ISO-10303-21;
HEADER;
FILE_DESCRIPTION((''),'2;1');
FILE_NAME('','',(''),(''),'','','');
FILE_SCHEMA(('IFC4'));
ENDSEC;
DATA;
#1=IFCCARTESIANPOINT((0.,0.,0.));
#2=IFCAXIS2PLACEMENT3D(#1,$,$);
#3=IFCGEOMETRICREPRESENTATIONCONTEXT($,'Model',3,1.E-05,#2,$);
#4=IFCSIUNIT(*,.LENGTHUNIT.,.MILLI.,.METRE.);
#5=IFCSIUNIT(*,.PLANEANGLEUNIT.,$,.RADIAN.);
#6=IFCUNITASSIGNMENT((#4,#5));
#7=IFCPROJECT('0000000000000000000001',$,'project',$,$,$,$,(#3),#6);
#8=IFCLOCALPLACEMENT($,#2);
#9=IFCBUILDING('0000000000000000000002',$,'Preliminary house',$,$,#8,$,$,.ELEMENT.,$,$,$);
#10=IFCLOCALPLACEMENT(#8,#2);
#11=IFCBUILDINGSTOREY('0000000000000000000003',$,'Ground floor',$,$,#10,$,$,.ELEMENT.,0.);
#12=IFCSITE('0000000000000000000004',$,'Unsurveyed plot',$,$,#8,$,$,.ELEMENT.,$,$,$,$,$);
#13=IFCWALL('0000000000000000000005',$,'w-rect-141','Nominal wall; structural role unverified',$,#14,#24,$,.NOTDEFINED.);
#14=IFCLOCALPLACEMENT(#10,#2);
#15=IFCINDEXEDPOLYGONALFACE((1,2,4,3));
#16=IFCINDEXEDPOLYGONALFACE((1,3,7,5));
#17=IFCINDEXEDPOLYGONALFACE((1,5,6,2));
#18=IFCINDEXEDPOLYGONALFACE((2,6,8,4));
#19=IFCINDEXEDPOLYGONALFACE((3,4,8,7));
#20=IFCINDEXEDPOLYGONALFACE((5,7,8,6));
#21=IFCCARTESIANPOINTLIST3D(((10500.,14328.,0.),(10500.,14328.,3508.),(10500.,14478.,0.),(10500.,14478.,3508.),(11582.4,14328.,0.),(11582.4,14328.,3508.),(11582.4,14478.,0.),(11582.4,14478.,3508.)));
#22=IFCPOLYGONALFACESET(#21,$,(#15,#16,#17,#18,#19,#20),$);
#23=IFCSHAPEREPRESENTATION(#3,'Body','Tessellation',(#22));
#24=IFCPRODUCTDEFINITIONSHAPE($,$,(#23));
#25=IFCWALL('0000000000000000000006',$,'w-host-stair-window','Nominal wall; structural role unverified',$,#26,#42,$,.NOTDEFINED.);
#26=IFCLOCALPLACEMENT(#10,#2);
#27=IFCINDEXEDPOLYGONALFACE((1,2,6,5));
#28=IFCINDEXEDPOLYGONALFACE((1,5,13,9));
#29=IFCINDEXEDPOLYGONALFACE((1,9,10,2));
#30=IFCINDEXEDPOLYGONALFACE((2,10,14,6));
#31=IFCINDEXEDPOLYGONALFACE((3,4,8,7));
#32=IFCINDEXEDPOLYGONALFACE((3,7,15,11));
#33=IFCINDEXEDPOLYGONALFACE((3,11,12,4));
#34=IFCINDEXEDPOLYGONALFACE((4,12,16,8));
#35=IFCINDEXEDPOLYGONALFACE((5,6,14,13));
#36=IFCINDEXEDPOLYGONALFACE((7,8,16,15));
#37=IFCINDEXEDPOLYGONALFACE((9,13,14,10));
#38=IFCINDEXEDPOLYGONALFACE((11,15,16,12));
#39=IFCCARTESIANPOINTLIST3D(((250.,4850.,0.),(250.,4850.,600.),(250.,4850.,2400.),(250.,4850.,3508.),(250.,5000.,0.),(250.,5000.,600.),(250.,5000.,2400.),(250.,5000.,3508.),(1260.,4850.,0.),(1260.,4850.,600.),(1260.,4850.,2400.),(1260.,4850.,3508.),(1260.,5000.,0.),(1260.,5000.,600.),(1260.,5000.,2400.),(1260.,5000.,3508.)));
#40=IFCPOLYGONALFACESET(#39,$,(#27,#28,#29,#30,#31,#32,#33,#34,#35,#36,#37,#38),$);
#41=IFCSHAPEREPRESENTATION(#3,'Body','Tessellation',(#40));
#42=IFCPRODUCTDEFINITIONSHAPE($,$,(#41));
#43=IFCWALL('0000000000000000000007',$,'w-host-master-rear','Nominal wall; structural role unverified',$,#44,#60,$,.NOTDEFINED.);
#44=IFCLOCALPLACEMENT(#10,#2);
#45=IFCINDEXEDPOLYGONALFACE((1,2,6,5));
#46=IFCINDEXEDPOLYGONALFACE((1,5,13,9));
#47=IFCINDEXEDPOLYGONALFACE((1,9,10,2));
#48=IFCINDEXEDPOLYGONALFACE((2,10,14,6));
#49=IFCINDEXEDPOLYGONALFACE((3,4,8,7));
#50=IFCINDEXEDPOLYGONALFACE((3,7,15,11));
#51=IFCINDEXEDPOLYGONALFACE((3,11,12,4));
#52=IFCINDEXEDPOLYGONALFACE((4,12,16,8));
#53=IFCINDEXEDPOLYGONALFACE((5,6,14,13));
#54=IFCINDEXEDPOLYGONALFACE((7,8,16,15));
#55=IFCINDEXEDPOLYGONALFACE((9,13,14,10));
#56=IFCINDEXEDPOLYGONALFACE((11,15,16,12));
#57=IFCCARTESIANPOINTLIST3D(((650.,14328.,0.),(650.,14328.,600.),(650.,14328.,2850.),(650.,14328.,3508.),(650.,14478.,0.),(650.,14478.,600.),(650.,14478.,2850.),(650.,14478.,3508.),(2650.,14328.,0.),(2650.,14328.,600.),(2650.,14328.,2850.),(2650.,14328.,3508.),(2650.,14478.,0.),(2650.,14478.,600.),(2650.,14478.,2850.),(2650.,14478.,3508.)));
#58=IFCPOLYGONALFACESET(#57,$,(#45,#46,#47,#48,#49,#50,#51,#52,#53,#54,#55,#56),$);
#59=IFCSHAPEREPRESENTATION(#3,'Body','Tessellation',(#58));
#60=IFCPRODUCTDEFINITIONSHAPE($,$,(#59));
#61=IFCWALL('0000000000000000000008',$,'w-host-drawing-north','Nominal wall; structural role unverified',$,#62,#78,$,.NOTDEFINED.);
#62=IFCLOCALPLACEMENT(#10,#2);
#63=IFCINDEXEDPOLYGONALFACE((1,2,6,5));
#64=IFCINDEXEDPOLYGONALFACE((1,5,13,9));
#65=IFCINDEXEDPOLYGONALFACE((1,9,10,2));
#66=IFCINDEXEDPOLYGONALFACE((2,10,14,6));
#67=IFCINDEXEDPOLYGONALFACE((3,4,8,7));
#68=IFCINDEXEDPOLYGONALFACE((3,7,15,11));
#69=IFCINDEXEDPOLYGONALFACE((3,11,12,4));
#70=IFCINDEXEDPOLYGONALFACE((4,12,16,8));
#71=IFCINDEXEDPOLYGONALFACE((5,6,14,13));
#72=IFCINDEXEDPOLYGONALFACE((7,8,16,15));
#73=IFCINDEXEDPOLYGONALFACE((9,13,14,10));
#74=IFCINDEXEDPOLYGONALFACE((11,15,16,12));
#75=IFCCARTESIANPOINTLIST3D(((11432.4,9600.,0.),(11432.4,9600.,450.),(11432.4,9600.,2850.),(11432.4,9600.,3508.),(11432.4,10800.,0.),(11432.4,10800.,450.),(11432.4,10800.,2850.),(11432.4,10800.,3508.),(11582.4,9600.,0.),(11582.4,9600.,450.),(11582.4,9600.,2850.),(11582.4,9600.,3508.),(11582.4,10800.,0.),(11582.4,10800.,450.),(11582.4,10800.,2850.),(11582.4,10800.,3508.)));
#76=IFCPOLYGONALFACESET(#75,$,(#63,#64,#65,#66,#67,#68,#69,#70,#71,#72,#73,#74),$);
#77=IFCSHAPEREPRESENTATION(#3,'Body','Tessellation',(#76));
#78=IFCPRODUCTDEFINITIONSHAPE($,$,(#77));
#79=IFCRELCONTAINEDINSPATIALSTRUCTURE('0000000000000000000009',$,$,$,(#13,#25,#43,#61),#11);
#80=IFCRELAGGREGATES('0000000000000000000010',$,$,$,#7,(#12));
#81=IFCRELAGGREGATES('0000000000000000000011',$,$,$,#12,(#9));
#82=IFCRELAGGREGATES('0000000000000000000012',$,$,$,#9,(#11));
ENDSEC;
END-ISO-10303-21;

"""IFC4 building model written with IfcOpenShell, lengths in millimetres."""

from ifc_helpers import new_model, si_unit, frame, origin, place, context, project, spatial, polyline, outline, extrude, element, save


model = new_model("IFC4")

# Units and contexts
model_context = context("Model", 3, precision=1e-05, world=origin())
ifc_project = project(units=[si_unit("LENGTHUNIT", "METRE", prefix="MILLI"), si_unit("PLANEANGLEUNIT", "RADIAN")], contexts=[model_context])

# Site, building, storey
placement_1 = place(None, origin())
site = spatial("IfcSite", under=ifc_project, at=placement_1, Name="Unsurveyed plot", CompositionType="ELEMENT")
building = spatial("IfcBuilding", under=site, at=placement_1, Name="Preliminary house", CompositionType="ELEMENT")
placement_2 = place(placement_1, origin())
storey = spatial("IfcBuildingStorey", under=building, at=placement_2, Name="Ground floor", CompositionType="ELEMENT", Elevation=0.0)

# Wall
element("IfcWall", 1, at=placement_2, inside=storey, Name="w-rect-141", Description="Nominal wall; structural role unverified", PredefinedType="NOTDEFINED", context=model_context, shape_type="SweptSolid", body=[
    extrude(outline(polyline([(10500.0, 14328.0), (11582.4, 14328.0), (11582.4, 14478.0), (10500.0, 14478.0), (10500.0, 14328.0)])), origin(), (0.0, 0.0, 1.0), 3508.0),
])

# Walls, openings
wall_1 = element("IfcWall", 2, at=placement_2, inside=storey, Name="w-host-stair-window", Description="Nominal wall; structural role unverified", PredefinedType="NOTDEFINED", context=model_context, shape_type="SweptSolid", body=[
    extrude(outline(polyline([(250.0, 4850.0), (1260.0, 4850.0), (1260.0, 5000.0), (250.0, 5000.0), (250.0, 4850.0)])), origin(), (0.0, 0.0, 1.0), 3508.0),
])
element("IfcOpeningElement", 3, at=placement_2, cuts=wall_1, PredefinedType="OPENING", context=model_context, shape_type="SweptSolid", body=[
    extrude(outline(polyline([(250.0, 4475.0), (1260.0, 4475.0), (1260.0, 5375.0), (250.0, 5375.0), (250.0, 4475.0)])), frame((0.0, 0.0, 600.0)), (0.0, 0.0, 1.0), 1800.0),
])
wall_2 = element("IfcWall", 4, at=placement_2, inside=storey, Name="w-host-master-rear", Description="Nominal wall; structural role unverified", PredefinedType="NOTDEFINED", context=model_context, shape_type="SweptSolid", body=[
    extrude(outline(polyline([(650.0, 14328.0), (2650.0, 14328.0), (2650.0, 14478.0), (650.0, 14478.0), (650.0, 14328.0)])), origin(), (0.0, 0.0, 1.0), 3508.0),
])
element("IfcOpeningElement", 5, at=placement_2, cuts=wall_2, PredefinedType="OPENING", context=model_context, shape_type="SweptSolid", body=[
    extrude(outline(polyline([(650.0, 13953.0), (2650.0, 13953.0), (2650.0, 14853.0), (650.0, 14853.0), (650.0, 13953.0)])), frame((0.0, 0.0, 600.0)), (0.0, 0.0, 1.0), 2250.0),
])
wall_3 = element("IfcWall", 6, at=placement_2, inside=storey, Name="w-host-drawing-north", Description="Nominal wall; structural role unverified", PredefinedType="NOTDEFINED", context=model_context, shape_type="SweptSolid", body=[
    extrude(outline(polyline([(11582.4, 9600.0), (11582.4, 10800.0), (11432.4, 10800.0), (11432.4, 9600.0), (11582.4, 9600.0)])), origin(), (0.0, 0.0, 1.0), 3508.0),
])
element("IfcOpeningElement", 7, at=placement_2, cuts=wall_3, PredefinedType="OPENING", context=model_context, shape_type="SweptSolid", body=[
    extrude(outline(polyline([(11957.4, 9600.0), (11957.4, 10800.0), (11057.4, 10800.0), (11057.4, 9600.0), (11957.4, 9600.0)])), frame((0.0, 0.0, 450.0)), (0.0, 0.0, 1.0), 2400.0),
])

save(model, "model.ifc")
